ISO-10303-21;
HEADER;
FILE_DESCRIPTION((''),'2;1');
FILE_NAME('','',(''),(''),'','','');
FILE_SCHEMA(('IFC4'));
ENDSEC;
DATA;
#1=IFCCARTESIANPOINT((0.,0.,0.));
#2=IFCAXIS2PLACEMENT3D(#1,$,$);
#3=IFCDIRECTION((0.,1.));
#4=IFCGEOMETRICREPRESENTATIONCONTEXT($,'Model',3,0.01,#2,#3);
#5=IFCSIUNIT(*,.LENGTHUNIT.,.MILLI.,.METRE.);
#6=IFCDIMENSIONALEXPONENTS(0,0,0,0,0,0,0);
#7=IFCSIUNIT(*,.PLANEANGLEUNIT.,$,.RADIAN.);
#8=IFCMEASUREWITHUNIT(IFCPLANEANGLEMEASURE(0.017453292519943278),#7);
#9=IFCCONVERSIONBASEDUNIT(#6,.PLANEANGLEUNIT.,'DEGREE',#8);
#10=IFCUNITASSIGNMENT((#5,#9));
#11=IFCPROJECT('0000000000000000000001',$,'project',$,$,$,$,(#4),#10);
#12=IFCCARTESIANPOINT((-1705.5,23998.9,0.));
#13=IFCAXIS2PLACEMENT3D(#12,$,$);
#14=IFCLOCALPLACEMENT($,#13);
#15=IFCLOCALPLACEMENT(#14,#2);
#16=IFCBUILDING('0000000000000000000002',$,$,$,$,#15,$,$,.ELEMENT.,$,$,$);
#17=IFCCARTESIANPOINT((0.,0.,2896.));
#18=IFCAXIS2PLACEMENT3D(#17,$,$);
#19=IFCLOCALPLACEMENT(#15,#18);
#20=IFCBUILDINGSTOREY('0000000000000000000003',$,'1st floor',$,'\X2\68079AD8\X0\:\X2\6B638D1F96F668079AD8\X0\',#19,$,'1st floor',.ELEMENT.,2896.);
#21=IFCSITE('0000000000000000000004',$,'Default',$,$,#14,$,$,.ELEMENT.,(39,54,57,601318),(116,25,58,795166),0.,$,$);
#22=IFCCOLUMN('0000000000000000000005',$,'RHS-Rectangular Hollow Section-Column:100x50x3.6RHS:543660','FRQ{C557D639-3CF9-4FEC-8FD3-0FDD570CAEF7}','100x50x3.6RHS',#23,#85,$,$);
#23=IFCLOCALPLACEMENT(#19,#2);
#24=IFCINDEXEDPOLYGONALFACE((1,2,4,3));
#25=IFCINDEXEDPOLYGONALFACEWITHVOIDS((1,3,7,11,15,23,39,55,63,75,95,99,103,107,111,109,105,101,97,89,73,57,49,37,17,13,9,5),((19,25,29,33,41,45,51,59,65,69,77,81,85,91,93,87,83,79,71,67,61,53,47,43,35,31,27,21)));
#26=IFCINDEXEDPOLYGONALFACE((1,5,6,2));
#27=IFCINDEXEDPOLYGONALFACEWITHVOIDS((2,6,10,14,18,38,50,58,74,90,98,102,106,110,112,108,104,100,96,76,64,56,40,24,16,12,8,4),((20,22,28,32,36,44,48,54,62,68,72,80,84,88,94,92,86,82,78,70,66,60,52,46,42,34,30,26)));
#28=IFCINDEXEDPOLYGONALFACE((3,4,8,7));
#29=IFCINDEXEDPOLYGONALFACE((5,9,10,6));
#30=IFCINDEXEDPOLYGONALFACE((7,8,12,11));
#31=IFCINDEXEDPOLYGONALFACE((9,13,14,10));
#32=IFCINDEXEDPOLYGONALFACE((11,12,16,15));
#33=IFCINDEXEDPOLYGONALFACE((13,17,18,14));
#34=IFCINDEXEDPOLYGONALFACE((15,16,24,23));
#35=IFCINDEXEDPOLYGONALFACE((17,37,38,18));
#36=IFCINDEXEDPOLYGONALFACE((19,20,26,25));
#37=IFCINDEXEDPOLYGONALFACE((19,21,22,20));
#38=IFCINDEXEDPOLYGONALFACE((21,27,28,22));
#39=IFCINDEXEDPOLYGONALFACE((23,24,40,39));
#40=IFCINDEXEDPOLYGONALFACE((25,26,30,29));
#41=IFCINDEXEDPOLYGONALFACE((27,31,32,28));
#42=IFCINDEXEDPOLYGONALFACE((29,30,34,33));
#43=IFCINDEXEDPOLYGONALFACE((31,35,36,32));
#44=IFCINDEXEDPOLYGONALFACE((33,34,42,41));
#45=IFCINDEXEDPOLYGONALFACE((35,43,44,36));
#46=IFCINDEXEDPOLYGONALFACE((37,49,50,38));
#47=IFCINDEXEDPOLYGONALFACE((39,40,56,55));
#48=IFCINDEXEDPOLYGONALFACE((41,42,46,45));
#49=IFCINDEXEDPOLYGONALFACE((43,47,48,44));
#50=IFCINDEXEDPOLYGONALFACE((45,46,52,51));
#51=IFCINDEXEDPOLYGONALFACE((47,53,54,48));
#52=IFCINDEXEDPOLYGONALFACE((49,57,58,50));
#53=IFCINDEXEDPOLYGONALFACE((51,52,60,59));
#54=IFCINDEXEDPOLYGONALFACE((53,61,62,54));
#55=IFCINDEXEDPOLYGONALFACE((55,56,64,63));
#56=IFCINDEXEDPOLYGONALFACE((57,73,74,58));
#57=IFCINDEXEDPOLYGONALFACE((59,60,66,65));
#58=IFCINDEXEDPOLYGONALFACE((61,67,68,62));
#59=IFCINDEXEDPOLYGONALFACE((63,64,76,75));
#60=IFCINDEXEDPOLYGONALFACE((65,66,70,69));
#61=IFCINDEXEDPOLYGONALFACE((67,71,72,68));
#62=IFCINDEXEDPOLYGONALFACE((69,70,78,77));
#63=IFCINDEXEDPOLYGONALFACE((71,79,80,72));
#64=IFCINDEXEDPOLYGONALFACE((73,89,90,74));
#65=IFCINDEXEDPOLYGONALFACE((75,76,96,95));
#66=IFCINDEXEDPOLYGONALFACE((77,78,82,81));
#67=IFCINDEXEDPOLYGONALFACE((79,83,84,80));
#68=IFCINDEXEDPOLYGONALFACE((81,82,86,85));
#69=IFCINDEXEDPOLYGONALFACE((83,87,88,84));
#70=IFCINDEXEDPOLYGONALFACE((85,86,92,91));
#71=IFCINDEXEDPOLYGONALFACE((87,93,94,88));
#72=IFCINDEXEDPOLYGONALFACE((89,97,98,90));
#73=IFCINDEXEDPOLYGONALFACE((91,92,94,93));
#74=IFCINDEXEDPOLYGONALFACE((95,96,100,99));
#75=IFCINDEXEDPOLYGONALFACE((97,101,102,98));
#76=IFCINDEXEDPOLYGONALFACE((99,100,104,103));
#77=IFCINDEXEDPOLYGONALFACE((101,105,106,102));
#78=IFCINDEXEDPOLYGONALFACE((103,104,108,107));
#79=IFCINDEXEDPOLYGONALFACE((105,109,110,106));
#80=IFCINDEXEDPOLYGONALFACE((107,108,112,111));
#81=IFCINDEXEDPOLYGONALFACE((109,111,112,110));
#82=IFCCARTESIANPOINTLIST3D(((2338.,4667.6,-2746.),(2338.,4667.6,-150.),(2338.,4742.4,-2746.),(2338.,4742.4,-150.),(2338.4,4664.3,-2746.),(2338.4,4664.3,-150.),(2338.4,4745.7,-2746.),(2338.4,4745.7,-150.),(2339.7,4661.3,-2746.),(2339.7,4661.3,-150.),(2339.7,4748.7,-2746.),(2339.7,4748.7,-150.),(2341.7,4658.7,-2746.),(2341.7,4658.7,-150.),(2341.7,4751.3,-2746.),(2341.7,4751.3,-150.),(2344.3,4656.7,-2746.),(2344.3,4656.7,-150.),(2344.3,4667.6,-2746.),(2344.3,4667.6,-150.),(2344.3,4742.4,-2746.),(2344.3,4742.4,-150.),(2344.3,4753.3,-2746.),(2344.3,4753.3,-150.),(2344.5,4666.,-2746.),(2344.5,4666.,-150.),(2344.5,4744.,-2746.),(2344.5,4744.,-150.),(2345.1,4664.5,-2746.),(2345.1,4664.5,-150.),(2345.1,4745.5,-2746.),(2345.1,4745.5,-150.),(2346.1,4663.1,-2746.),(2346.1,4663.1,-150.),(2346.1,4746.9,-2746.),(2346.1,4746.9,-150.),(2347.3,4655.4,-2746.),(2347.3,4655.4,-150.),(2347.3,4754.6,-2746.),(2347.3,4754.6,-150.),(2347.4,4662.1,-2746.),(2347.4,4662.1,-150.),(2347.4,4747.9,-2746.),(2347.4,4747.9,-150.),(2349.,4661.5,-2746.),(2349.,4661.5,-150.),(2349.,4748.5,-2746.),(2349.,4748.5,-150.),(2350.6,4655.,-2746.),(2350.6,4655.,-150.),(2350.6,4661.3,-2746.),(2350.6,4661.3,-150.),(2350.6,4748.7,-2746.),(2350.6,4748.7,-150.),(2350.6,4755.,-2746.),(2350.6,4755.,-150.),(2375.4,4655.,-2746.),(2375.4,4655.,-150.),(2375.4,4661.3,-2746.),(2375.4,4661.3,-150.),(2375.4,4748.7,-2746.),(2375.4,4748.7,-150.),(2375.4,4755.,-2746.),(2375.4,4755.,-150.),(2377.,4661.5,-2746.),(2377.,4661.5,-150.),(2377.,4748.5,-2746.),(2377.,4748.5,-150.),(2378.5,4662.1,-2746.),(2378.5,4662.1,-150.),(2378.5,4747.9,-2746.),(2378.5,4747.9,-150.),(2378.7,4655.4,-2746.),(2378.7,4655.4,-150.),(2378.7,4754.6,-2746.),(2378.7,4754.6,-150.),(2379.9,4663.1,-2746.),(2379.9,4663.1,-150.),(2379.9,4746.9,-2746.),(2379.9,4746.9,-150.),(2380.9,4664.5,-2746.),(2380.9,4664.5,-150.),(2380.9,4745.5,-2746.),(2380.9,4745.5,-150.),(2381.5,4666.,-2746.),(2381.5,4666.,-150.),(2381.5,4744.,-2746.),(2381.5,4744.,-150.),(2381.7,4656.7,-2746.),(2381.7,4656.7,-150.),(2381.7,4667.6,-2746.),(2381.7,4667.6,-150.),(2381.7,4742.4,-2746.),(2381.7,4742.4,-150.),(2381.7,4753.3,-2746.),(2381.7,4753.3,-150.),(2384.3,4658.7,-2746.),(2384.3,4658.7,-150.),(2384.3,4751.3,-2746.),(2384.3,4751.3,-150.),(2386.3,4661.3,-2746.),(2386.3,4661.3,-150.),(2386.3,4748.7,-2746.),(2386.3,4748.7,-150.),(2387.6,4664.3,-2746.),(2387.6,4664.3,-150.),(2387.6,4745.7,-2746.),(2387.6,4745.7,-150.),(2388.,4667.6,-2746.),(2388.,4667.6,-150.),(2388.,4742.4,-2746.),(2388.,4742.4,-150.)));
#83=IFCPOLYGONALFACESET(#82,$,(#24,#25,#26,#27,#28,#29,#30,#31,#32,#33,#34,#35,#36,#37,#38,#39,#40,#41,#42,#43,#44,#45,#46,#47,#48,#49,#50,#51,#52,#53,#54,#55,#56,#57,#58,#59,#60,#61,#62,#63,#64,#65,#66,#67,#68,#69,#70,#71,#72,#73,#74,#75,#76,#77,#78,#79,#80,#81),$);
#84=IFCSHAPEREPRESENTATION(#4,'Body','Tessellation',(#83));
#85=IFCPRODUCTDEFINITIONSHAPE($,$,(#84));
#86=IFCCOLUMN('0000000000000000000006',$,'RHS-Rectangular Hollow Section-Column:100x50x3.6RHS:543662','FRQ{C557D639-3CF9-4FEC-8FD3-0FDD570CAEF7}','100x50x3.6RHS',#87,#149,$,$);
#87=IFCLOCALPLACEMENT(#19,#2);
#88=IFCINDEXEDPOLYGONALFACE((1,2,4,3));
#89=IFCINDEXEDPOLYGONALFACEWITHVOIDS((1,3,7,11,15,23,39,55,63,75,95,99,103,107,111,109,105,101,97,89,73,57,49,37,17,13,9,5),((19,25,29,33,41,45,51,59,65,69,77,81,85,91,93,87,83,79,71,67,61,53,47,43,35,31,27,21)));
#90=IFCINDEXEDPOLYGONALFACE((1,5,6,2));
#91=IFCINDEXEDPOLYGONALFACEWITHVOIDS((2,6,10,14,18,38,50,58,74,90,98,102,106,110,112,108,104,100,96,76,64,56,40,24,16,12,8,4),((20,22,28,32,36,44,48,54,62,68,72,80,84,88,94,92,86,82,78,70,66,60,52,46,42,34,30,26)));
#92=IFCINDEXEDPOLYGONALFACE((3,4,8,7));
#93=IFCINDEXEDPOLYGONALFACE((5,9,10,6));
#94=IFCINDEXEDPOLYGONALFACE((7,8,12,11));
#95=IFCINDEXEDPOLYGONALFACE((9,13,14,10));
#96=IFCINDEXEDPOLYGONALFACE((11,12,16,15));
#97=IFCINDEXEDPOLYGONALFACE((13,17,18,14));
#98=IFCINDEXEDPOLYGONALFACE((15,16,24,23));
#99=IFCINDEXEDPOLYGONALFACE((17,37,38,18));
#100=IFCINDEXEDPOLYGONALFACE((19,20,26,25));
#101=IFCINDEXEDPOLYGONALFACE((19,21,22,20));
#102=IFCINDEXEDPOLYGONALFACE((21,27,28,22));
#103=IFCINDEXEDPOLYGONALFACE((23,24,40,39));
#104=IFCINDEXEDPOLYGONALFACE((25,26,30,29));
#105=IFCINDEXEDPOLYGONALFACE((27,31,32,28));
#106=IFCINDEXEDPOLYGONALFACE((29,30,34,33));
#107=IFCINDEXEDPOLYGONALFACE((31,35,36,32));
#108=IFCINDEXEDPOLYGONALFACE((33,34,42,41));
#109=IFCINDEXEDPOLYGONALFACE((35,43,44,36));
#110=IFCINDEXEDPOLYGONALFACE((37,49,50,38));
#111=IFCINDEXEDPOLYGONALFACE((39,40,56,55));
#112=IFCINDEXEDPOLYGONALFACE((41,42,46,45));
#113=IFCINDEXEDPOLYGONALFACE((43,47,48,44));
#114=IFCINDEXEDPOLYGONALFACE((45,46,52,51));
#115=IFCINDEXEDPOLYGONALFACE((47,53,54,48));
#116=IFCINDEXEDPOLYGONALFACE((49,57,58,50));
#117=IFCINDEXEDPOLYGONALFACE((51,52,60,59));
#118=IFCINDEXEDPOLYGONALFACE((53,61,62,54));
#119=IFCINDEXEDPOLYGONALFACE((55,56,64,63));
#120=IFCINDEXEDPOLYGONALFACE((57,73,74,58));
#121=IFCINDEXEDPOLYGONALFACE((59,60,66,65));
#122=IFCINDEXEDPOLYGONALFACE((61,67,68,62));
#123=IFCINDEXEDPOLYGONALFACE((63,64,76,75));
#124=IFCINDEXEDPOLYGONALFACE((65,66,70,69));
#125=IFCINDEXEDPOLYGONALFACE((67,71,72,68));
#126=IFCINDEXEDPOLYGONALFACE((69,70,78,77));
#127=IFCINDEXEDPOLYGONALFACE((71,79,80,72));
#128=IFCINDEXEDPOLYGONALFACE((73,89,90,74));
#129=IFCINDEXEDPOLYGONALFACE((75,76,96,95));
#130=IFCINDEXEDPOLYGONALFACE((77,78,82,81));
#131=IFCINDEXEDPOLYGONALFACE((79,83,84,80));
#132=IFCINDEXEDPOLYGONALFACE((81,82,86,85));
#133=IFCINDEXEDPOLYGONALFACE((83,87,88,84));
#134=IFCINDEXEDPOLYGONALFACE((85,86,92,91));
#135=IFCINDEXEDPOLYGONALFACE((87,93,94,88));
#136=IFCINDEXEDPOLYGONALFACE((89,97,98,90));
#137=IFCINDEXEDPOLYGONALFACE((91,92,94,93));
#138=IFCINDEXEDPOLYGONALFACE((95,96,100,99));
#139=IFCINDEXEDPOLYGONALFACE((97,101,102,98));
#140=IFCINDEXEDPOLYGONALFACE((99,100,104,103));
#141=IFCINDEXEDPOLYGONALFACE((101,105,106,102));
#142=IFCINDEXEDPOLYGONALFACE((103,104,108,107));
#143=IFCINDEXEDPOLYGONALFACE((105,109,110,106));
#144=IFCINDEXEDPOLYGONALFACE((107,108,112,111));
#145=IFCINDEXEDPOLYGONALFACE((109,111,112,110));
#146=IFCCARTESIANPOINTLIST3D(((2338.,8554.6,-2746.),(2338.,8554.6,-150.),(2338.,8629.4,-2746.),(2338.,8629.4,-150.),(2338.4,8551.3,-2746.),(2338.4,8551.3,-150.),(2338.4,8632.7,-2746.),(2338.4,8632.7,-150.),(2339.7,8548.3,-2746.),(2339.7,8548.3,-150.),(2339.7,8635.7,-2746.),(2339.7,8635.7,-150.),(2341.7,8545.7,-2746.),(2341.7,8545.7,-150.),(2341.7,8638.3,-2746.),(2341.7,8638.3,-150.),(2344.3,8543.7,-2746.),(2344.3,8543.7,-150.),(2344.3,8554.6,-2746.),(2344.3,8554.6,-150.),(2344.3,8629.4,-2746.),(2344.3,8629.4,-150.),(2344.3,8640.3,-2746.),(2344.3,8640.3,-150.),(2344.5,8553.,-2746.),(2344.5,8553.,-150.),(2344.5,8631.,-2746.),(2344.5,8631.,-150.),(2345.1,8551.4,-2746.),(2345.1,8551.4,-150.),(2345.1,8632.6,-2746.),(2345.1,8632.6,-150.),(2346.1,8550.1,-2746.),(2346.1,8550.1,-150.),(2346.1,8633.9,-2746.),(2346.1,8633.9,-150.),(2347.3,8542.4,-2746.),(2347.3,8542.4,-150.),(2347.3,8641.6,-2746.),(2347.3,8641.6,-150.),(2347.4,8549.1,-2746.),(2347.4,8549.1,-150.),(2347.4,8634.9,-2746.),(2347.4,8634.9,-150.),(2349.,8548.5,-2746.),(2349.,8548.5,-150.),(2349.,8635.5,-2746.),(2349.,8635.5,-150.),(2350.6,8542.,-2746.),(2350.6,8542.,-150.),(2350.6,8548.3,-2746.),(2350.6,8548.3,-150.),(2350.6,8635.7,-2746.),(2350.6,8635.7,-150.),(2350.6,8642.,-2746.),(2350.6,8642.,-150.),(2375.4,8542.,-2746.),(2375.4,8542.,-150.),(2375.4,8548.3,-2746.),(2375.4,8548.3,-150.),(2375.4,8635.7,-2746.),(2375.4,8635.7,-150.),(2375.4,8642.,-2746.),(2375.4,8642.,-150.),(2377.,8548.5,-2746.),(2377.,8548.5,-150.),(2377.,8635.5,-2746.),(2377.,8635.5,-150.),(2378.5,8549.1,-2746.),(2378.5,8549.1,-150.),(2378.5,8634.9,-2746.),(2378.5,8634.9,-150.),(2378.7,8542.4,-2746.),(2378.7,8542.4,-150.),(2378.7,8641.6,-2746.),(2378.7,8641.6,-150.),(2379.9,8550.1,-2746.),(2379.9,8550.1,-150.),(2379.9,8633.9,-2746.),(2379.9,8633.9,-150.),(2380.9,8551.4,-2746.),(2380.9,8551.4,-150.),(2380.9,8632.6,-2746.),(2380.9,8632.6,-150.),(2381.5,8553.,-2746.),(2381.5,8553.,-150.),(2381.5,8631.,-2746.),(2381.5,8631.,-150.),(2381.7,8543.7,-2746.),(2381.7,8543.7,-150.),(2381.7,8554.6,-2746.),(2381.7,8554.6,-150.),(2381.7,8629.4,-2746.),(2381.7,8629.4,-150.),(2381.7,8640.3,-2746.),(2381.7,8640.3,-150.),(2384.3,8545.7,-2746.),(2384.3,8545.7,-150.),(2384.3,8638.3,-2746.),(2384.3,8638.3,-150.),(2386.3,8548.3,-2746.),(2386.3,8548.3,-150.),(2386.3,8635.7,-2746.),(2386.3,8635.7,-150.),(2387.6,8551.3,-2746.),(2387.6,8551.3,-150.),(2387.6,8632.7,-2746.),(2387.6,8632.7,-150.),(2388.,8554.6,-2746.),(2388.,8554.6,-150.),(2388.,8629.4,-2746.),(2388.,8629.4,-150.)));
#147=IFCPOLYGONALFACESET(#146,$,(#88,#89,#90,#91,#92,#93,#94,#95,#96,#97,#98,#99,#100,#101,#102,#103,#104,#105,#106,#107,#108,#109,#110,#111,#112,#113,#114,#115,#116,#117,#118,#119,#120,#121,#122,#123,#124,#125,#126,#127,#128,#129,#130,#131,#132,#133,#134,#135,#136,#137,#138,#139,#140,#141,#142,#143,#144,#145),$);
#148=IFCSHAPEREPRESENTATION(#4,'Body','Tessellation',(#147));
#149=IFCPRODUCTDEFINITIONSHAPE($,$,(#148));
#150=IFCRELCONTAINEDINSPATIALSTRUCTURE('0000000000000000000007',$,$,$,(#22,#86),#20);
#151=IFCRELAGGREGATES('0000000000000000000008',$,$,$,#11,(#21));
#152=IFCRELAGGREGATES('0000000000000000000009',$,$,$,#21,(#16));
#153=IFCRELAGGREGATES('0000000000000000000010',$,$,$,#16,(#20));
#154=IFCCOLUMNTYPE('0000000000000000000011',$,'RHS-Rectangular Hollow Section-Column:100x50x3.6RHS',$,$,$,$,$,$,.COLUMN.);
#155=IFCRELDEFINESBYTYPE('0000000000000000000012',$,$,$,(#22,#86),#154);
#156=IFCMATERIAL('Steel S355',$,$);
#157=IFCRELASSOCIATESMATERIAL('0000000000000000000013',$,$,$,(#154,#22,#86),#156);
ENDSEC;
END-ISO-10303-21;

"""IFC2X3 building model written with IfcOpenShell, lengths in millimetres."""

from ifc_helpers import new_model, entity, si_unit, converted_unit, direction, frame, origin, origin_2d, place, context, project, spatial, hollow_rectangle, extrude, clip, halfspace, material, type_object, element, save


model = new_model("IFC2X3")

# Units and contexts
model_context = context("Model", 3, precision=0.01, world=origin(), true_north=direction((0.0, 1.0)))
ifc_project = project(units=[si_unit("LENGTHUNIT", "METRE", prefix="MILLI"), converted_unit("PLANEANGLEUNIT", "DEGREE", entity("IfcPlaneAngleMeasure", 0.017453292519943278), si_unit("PLANEANGLEUNIT", "RADIAN"), dimensions=[0, 0, 0, 0, 0, 0, 0])], contexts=[model_context])

# Site, building, storey
site_placement = place(None, frame((-1705.5, 23998.9, 0.0)))
site = spatial("IfcSite", under=ifc_project, at=site_placement, Name="Default", CompositionType="ELEMENT", RefLatitude=(39, 54, 57, 601318), RefLongitude=(116, 25, 58, 795166), RefElevation=0.0)
building_placement = place(site_placement, origin())
building = spatial("IfcBuilding", under=site, at=building_placement, CompositionType="ELEMENT")
storey_placement = place(building_placement, frame((0.0, 0.0, 2896.0)))
storey = spatial("IfcBuildingStorey", under=building, at=storey_placement, Name="1st floor", ObjectType="标高:正负零标高", LongName="1st floor", CompositionType="ELEMENT", Elevation=2896.0)

# Columns
ifc_material_1 = material(Name="Steel S355")
column_type = type_object("IfcColumnType", Name="RHS-Rectangular Hollow Section-Column:100x50x3.6RHS", PredefinedType="COLUMN", material=ifc_material_1)
column_1_placement = place(storey_placement, frame((2363.0, 4705.0, -150.0), z_axis=(0.0, 0.0, 1.0), x_axis=(-1.0, 0.0, 0.0)))
element("IfcColumn", 1, at=column_1_placement, inside=storey, type_object=column_type, material=ifc_material_1, Name="RHS-Rectangular Hollow Section-Column:100x50x3.6RHS:543660", Description="FRQ{C557D639-3CF9-4FEC-8FD3-0FDD570CAEF7}", ObjectType="100x50x3.6RHS", context=model_context, shape_type="Clipping", body=[
    clip(extrude(hollow_rectangle(XDim=50.0, YDim=100.0, WallThickness=6.3, InnerFilletRadius=6.3, OuterFilletRadius=12.6, at=origin_2d()), origin(), (0.0, 0.0, -1.0), 2651.9), halfspace(frame((2363.0, 4705.0, -2596.0), z_axis=(0.0, 0.0, 1.0), x_axis=(-1.0, 0.0, 0.0)), True)),
])
column_2_placement = place(storey_placement, frame((2363.0, 8592.0, -150.0), z_axis=(0.0, 0.0, 1.0), x_axis=(-1.0, 0.0, 0.0)))
element("IfcColumn", 2, at=column_2_placement, inside=storey, type_object=column_type, material=ifc_material_1, Name="RHS-Rectangular Hollow Section-Column:100x50x3.6RHS:543662", Description="FRQ{C557D639-3CF9-4FEC-8FD3-0FDD570CAEF7}", ObjectType="100x50x3.6RHS", context=model_context, shape_type="Clipping", body=[
    clip(extrude(hollow_rectangle(XDim=50.0, YDim=100.0, WallThickness=6.3, InnerFilletRadius=6.3, OuterFilletRadius=12.6, at=origin_2d()), origin(), (0.0, 0.0, -1.0), 2651.9), halfspace(frame((2363.0, 8592.0, -2596.0), z_axis=(0.0, 0.0, 1.0), x_axis=(-1.0, 0.0, 0.0)), True)),
])

save(model, "model.ifc")
